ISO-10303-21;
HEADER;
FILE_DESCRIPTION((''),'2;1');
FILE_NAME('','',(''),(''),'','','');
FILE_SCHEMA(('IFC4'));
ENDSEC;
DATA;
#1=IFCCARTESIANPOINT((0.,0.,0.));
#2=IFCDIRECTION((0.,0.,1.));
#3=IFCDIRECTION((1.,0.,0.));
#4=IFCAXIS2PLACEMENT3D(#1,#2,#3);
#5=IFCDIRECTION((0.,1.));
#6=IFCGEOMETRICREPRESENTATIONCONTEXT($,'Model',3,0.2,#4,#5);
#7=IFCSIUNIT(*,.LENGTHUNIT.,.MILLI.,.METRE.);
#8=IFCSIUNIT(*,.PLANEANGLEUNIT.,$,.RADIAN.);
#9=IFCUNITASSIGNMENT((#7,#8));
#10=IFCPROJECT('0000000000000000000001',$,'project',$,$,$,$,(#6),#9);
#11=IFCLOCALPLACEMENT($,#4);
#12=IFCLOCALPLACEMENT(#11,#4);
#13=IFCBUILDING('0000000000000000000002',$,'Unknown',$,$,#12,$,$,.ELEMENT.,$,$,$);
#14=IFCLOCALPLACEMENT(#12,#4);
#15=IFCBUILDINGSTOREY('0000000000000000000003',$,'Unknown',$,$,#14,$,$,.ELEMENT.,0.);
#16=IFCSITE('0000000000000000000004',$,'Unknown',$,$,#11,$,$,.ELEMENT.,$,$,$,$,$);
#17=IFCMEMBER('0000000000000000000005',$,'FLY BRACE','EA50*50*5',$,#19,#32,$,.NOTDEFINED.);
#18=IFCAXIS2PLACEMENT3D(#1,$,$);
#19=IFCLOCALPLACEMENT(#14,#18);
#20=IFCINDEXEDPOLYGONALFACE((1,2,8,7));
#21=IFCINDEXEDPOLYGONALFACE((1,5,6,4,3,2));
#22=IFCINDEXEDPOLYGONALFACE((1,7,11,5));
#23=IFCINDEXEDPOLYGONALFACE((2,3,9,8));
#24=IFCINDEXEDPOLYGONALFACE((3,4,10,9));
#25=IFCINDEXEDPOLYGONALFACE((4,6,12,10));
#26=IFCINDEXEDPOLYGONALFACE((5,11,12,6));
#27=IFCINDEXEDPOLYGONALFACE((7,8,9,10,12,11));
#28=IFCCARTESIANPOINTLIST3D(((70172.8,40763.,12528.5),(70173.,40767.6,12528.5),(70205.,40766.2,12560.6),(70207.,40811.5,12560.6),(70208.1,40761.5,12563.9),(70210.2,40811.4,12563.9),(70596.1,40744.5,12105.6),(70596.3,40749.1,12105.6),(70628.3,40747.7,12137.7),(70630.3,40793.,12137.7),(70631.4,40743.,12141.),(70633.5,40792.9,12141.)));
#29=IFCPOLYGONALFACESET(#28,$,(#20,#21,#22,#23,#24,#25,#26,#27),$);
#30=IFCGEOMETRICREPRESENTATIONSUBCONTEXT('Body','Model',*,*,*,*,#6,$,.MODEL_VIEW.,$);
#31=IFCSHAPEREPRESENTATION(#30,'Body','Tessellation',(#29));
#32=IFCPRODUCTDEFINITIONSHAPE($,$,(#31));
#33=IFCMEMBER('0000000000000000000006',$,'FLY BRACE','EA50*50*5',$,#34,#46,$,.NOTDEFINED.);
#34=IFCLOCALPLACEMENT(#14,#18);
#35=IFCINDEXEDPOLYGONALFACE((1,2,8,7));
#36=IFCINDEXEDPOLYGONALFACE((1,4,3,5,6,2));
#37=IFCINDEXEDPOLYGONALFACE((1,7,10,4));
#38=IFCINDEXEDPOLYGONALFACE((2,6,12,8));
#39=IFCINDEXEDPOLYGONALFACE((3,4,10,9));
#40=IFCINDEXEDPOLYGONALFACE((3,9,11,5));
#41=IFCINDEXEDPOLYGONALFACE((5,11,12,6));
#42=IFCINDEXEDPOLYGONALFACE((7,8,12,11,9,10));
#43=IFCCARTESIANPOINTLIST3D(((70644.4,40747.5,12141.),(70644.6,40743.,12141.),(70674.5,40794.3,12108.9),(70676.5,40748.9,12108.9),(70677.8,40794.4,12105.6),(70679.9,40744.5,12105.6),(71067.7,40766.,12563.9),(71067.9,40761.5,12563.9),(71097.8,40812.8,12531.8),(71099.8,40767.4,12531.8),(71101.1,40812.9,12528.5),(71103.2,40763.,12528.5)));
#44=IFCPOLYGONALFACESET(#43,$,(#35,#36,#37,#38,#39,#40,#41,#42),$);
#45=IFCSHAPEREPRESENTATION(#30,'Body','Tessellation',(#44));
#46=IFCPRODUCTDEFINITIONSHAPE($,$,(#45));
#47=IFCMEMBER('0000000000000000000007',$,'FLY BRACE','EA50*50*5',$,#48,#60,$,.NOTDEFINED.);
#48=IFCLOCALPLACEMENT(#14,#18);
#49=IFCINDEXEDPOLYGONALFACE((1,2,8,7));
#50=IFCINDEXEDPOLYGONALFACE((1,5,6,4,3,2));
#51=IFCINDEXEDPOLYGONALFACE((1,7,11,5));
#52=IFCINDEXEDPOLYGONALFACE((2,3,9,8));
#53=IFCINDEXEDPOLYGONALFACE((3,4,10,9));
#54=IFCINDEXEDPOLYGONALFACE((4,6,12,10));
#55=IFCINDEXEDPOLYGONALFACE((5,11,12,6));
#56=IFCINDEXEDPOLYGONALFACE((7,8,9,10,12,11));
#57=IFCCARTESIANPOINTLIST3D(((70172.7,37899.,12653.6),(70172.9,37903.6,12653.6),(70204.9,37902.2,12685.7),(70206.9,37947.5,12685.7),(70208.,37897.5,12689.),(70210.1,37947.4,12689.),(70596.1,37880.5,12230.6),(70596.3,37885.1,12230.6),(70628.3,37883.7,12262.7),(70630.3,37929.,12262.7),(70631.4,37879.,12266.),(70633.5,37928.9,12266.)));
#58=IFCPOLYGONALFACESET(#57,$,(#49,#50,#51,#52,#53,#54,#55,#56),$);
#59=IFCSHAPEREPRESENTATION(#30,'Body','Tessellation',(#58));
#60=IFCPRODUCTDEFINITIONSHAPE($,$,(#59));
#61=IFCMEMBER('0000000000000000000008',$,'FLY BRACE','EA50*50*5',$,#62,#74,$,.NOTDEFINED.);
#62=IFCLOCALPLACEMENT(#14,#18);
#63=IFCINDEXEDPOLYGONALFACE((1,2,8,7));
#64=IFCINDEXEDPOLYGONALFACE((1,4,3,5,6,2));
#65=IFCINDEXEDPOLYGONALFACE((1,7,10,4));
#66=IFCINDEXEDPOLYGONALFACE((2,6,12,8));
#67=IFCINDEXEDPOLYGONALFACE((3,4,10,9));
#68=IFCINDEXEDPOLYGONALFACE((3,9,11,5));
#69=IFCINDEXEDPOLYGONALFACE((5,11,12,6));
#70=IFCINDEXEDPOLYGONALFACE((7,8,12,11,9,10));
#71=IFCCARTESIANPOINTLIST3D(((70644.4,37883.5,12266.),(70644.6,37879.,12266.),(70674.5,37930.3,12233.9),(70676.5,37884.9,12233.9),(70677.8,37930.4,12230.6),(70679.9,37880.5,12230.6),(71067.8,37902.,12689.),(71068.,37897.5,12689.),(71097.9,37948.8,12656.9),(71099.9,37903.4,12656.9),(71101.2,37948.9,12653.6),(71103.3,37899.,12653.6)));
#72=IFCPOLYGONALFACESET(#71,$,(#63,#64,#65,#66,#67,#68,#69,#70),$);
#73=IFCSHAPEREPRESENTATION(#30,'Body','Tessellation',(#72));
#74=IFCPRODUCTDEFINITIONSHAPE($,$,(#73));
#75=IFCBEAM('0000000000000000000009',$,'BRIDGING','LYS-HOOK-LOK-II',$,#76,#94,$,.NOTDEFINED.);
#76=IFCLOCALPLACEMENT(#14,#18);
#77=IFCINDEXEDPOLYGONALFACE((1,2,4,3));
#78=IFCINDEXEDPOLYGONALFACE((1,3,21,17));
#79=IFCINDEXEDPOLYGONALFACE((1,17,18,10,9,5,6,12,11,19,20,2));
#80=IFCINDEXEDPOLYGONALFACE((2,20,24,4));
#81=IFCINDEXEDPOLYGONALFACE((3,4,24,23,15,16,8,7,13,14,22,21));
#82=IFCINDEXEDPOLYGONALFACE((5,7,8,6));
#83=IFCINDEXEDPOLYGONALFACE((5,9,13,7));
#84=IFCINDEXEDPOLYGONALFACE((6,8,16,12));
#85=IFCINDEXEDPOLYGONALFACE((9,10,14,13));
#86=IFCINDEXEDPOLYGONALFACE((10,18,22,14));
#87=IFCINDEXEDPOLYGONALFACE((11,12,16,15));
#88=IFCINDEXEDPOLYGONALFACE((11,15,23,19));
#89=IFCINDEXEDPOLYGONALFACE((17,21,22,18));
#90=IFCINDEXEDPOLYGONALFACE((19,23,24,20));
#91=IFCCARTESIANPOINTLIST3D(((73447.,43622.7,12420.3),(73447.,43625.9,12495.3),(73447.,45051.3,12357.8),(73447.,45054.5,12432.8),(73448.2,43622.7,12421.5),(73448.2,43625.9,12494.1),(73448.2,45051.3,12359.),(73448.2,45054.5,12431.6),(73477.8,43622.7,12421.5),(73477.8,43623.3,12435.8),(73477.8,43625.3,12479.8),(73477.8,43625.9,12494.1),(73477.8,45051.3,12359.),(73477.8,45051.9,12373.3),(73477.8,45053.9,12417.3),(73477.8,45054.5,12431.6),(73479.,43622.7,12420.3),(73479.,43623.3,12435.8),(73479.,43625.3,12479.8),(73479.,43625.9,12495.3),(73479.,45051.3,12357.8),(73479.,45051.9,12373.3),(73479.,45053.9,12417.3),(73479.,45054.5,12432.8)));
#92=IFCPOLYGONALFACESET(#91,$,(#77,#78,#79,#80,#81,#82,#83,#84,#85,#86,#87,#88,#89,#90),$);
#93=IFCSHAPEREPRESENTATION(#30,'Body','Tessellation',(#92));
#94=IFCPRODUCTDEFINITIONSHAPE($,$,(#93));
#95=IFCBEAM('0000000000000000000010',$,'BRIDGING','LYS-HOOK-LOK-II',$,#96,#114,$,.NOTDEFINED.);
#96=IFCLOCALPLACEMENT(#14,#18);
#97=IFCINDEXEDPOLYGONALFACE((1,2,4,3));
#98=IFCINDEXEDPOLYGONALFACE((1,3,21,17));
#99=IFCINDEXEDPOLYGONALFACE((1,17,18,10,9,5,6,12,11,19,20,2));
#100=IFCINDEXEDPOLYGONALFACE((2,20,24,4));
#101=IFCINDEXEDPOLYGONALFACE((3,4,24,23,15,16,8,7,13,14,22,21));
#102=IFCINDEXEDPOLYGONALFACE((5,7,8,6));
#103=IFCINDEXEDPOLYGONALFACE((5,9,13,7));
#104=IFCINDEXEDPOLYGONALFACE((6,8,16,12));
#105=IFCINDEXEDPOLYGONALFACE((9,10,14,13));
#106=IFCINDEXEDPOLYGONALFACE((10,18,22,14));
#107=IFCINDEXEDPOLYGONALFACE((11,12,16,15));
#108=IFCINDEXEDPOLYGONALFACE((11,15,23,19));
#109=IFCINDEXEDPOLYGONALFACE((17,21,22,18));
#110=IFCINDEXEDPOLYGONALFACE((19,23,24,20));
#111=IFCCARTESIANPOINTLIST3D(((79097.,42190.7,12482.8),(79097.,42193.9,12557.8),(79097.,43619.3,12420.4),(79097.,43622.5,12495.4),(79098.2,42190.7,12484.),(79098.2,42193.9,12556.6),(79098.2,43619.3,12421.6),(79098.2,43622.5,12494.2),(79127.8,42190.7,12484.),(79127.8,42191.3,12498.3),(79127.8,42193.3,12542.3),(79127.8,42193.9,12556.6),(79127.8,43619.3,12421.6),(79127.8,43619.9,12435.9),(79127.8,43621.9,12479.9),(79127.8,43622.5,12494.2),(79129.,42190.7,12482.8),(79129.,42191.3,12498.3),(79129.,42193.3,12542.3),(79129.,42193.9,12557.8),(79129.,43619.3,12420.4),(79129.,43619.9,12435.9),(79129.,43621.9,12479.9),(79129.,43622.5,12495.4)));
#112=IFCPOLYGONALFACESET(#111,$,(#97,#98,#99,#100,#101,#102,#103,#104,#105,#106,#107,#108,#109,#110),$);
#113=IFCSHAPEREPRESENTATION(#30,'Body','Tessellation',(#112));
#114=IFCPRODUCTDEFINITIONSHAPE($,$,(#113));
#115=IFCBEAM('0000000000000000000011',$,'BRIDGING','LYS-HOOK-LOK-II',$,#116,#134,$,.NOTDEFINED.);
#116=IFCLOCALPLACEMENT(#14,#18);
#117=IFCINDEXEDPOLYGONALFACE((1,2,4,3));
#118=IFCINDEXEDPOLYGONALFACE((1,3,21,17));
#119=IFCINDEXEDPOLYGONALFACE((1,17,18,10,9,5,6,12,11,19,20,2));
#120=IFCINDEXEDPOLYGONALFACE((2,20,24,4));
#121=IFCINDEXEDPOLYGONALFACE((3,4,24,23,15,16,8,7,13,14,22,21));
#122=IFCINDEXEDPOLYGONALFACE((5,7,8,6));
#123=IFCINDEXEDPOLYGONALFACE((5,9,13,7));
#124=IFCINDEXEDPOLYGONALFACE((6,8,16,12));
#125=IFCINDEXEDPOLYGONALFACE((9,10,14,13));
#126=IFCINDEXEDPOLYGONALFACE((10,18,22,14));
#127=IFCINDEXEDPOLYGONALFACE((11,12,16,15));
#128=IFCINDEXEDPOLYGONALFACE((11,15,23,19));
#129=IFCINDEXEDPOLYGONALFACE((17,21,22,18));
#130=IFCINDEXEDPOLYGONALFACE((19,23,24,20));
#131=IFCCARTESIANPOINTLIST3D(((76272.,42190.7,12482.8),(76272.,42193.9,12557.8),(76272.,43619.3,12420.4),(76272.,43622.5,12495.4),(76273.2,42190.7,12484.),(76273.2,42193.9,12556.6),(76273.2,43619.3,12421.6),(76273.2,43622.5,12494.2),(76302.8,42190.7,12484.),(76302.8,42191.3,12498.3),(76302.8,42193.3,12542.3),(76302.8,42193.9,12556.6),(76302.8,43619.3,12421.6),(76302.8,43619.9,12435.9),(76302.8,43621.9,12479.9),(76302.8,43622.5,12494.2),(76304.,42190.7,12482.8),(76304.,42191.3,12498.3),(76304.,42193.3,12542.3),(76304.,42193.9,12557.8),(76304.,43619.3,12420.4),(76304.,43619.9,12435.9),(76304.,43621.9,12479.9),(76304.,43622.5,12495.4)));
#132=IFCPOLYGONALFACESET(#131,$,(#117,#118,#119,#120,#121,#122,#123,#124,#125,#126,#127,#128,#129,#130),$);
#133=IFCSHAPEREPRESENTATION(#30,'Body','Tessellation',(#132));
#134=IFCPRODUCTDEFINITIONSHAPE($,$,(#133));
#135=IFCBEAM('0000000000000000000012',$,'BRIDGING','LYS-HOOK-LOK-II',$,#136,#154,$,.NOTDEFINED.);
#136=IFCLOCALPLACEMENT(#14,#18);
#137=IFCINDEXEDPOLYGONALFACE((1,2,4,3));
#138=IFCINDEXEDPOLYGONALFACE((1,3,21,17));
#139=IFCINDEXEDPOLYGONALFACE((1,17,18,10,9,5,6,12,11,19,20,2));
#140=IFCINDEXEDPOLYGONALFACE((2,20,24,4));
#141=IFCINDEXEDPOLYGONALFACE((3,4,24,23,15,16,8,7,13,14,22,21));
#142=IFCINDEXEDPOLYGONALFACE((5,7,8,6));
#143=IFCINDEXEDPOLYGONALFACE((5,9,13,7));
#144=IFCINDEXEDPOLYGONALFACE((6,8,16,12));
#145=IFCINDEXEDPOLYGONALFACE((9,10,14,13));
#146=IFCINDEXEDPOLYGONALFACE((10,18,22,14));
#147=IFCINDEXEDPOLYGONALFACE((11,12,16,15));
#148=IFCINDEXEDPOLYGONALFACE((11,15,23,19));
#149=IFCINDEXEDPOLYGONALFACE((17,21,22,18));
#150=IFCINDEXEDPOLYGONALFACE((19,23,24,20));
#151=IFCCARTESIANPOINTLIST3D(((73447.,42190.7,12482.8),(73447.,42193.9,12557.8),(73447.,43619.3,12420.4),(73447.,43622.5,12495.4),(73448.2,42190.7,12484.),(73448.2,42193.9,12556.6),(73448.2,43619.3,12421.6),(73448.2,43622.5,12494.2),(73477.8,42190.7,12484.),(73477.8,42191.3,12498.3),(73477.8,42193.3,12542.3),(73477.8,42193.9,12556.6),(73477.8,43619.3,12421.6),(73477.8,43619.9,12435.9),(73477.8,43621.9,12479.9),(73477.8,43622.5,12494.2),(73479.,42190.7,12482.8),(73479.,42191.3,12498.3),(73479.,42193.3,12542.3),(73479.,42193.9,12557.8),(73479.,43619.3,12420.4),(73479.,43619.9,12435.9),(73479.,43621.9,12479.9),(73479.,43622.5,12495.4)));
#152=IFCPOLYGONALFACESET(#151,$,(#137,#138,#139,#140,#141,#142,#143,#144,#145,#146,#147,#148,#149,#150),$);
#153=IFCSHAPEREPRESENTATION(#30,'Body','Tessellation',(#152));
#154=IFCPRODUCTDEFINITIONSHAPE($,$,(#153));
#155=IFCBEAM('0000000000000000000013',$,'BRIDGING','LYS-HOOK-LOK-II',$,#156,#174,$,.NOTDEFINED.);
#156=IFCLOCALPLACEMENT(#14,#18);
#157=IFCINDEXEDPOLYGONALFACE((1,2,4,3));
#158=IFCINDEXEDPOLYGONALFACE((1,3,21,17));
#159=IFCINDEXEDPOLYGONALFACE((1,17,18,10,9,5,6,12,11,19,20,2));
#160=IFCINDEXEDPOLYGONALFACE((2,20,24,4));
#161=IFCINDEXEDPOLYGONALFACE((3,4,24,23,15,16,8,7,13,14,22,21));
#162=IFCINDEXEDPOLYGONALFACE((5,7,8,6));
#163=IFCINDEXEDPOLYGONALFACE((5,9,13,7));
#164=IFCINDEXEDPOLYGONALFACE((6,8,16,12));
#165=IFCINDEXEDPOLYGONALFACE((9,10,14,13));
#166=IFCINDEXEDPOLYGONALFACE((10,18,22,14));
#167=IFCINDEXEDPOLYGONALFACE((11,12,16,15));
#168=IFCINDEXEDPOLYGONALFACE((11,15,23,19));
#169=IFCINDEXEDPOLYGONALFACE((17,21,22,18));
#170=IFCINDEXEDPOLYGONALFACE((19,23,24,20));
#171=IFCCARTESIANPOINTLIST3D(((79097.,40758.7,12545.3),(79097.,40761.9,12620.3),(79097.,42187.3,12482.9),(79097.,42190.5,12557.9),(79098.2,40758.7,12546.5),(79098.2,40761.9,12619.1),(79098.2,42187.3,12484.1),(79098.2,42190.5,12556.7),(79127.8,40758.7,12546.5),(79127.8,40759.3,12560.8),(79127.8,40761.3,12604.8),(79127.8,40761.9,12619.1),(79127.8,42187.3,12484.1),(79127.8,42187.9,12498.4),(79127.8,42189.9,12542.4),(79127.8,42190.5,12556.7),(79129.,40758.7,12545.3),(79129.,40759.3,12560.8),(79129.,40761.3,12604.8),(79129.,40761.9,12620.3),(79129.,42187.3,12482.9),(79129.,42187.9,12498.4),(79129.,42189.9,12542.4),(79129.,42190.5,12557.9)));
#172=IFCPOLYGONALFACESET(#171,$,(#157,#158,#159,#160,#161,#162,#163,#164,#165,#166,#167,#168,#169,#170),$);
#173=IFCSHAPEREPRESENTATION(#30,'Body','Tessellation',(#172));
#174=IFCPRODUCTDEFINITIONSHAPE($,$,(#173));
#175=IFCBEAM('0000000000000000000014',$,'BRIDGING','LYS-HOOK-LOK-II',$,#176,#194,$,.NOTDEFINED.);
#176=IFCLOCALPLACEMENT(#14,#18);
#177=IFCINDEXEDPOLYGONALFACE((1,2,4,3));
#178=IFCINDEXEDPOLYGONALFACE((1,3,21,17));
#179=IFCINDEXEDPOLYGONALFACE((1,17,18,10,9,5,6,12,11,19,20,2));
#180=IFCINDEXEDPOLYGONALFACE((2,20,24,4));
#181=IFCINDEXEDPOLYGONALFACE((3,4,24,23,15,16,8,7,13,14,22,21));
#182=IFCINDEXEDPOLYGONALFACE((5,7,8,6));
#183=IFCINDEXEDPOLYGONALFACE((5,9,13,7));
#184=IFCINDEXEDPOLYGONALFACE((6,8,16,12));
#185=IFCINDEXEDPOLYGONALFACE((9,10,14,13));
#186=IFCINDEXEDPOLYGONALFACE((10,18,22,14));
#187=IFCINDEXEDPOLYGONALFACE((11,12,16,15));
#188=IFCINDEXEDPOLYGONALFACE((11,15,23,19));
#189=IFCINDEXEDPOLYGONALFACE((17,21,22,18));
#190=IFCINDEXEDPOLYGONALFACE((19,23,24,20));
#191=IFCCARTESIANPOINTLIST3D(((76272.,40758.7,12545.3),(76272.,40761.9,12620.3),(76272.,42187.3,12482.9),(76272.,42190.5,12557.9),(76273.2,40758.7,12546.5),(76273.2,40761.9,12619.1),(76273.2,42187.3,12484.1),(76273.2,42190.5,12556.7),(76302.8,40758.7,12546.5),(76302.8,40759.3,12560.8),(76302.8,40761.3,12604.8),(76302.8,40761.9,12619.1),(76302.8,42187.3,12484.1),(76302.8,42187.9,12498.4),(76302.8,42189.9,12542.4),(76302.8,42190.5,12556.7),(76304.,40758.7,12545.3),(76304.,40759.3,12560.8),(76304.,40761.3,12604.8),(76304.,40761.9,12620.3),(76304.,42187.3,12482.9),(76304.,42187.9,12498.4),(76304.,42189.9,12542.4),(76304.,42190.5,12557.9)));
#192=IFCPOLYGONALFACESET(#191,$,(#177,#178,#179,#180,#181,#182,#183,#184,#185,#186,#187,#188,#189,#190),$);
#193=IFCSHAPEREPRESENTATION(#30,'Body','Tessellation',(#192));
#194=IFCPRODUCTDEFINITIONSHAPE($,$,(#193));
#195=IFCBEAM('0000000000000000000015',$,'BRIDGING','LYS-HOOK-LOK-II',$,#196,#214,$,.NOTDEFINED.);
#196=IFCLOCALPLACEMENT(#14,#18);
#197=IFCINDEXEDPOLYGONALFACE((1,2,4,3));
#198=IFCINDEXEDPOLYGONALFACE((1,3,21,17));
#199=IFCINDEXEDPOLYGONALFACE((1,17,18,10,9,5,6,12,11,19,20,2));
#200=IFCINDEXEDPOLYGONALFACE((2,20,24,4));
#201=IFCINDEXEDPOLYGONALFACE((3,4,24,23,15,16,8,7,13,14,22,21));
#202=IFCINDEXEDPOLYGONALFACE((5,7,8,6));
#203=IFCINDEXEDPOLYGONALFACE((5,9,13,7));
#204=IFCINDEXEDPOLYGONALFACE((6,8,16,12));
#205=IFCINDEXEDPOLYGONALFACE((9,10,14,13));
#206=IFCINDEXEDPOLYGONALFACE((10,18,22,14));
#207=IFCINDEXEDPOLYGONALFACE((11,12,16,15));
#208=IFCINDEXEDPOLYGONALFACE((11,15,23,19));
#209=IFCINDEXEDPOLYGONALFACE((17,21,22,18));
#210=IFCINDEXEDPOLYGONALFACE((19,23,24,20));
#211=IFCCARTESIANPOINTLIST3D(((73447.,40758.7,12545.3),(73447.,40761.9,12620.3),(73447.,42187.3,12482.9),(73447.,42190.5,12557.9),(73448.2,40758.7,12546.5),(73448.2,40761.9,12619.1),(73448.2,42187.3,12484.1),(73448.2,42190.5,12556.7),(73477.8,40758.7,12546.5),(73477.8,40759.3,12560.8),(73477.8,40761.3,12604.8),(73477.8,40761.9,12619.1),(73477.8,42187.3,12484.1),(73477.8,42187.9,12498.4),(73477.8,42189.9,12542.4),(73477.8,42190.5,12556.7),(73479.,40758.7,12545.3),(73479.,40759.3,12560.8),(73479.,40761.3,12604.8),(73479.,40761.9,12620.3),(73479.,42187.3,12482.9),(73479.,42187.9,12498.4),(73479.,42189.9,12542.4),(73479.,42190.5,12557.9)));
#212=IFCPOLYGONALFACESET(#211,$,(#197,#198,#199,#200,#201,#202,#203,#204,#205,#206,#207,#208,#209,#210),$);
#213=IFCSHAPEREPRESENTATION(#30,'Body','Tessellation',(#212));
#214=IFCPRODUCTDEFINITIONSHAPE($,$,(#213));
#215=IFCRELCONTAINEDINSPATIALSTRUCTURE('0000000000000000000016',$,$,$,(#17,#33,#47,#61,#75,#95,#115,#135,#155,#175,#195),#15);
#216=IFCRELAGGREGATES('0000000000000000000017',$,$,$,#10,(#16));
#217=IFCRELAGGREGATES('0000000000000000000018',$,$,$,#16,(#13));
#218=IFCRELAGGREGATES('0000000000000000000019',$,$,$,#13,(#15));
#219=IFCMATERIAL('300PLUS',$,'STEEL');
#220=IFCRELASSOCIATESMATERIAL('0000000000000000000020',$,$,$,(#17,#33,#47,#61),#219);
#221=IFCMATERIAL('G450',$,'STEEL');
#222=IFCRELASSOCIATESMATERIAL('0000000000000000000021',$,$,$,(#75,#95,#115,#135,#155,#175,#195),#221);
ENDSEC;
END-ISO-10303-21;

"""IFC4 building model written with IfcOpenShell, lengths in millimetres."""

from ifc_helpers import new_model, si_unit, direction, frame, origin_with_axes, place, context, subcontext, project, spatial, line, indexed_curve, outline, extrude, material, element, save


model = new_model("IFC4")

# Units and contexts
model_context = context("Model", 3, precision=0.2, world=origin_with_axes(), true_north=direction((0.0, 1.0)))
body_context = subcontext(model_context, "Body", "Model", "MODEL_VIEW")
ifc_project = project(units=[si_unit("LENGTHUNIT", "METRE", prefix="MILLI"), si_unit("PLANEANGLEUNIT", "RADIAN")], contexts=[model_context])

# Site, building, storey
site_placement = place(None, origin_with_axes())
site = spatial("IfcSite", under=ifc_project, at=site_placement, Name="Unknown", CompositionType="ELEMENT")
building_placement = place(site_placement, origin_with_axes())
building = spatial("IfcBuilding", under=site, at=building_placement, Name="Unknown", CompositionType="ELEMENT")
storey_placement = place(building_placement, origin_with_axes())
storey = spatial("IfcBuildingStorey", under=building, at=storey_placement, Name="Unknown", CompositionType="ELEMENT", Elevation=0.0)

# Members
ifc_material_1 = material(Name="300PLUS", Category="STEEL")
for number, where, z_axis, x_axis, name in (
    (1, (70614.8, 40768.7, 12123.3), (-0.705761, 0.030845, -0.707778), (-0.707103, 0.030903, 0.706435), "FLY BRACE"),
    (2, (70661.2, 40768.7, 12123.3), (-0.705761, -0.030845, 0.707778), (0.707103, 0.030903, 0.706435), "FLY BRACE"),
):
    element("IfcMember", number, at=place(storey_placement, frame(where, z_axis=z_axis, x_axis=x_axis)), inside=storey, material=ifc_material_1, Name=name, Description="EA50*50*5", PredefinedType="NOTDEFINED", context=body_context, shape_type="SolidModel", body=[
        extrude(outline(indexed_curve([(-25.0, -25.0), (25.0, -25.0), (25.0, -20.4), (-20.4, -20.4), (-20.4, 25.0), (-25.0, 25.0)], segments=[line(1, 2, 3, 4, 5, 6, 1)])), frame((0.0, 0.0, 0.0), z_axis=(-1.0, 0.0, 0.0), x_axis=(0.0, 0.0, 1.0)), (0.0, 0.0, -1.0), 598.6),
    ])
for number, where, z_axis, x_axis, name in (
    (3, (70614.8, 37904.7, 12248.3), (-0.705762, 0.030837, -0.707778), (-0.707103, 0.030896, 0.706435), "FLY BRACE"),
    (4, (70661.2, 37904.7, 12248.3), (-0.705762, -0.030837, 0.707778), (0.707103, 0.030896, 0.706435), "FLY BRACE"),
):
    element("IfcMember", number, at=place(storey_placement, frame(where, z_axis=z_axis, x_axis=x_axis)), inside=storey, material=ifc_material_1, Name=name, Description="EA50*50*5", PredefinedType="NOTDEFINED", context=body_context, shape_type="SolidModel", body=[
        extrude(outline(indexed_curve([(-25.0, -25.0), (25.0, -25.0), (25.0, -20.4), (-20.4, -20.4), (-20.4, 25.0), (-25.0, 25.0)], segments=[line(1, 2, 3, 4, 5, 6, 1)])), frame((0.0, 0.0, 0.0), z_axis=(-1.0, 0.0, 0.0), x_axis=(0.0, 0.0, 1.0)), (0.0, 0.0, -1.0), 598.8),
    ])

# Beams
ifc_material_2 = material(Name="G450", Category="STEEL")
beam_placement = place(storey_placement, frame((73463.0, 43624.3, 12457.8), z_axis=(1.0, 0.0, 0.0), x_axis=(0.0, 0.999044, -0.043707)))
element("IfcBeam", 5, at=beam_placement, inside=storey, material=ifc_material_2, Name="BRIDGING", Description="LYS-HOOK-LOK-II", PredefinedType="NOTDEFINED", context=body_context, shape_type="SolidModel", body=[
    extrude(outline(indexed_curve([(16.0, -37.5), (16.0, -22.0), (14.8, -22.0), (14.8, -36.3), (-14.8, -36.3), (-14.8, 36.3), (14.8, 36.3), (14.8, 22.0), (16.0, 22.0), (16.0, 37.5), (-16.0, 37.5), (-16.0, -37.5)], segments=[line(1, 2, 3, 4, 5, 6, 7, 8, 9, 10, 11, 12, 1)])), frame((0.0, 0.0, 0.0), z_axis=(-1.0, 0.0, 0.0), x_axis=(0.0, 0.0, 1.0)), (0.0, 0.0, -1.0), 1430.0),
])
for number, where, z_axis, x_axis, name in (
    (6, (79113.0, 42192.3, 12520.3), (1.0, 0.0, 0.0), (0.0, 0.999047, -0.043638), "BRIDGING"),
    (7, (76288.0, 42192.3, 12520.3), (1.0, 0.0, 0.0), (0.0, 0.999047, -0.043638), "BRIDGING"),
    (8, (73463.0, 42192.3, 12520.3), (1.0, 0.0, 0.0), (0.0, 0.999047, -0.043638), "BRIDGING"),
    (9, (79113.0, 40760.3, 12582.8), (1.0, 0.0, 0.0), (0.0, 0.999047, -0.043638), "BRIDGING"),
    (10, (76288.0, 40760.3, 12582.8), (1.0, 0.0, 0.0), (0.0, 0.999047, -0.043638), "BRIDGING"),
    (11, (73463.0, 40760.3, 12582.8), (1.0, 0.0, 0.0), (0.0, 0.999047, -0.043638), "BRIDGING"),
):
    element("IfcBeam", number, at=place(storey_placement, frame(where, z_axis=z_axis, x_axis=x_axis)), inside=storey, material=ifc_material_2, Name=name, Description="LYS-HOOK-LOK-II", PredefinedType="NOTDEFINED", context=body_context, shape_type="SolidModel", body=[
        extrude(outline(indexed_curve([(16.0, -37.5), (16.0, -22.0), (14.8, -22.0), (14.8, -36.3), (-14.8, -36.3), (-14.8, 36.3), (14.8, 36.3), (14.8, 22.0), (16.0, 22.0), (16.0, 37.5), (-16.0, 37.5), (-16.0, -37.5)], segments=[line(1, 2, 3, 4, 5, 6, 7, 8, 9, 10, 11, 12, 1)])), frame((0.0, 0.0, 0.0), z_axis=(-1.0, 0.0, 0.0), x_axis=(0.0, 0.0, 1.0)), (0.0, 0.0, -1.0), 1430.0),
    ])

save(model, "model.ifc")
